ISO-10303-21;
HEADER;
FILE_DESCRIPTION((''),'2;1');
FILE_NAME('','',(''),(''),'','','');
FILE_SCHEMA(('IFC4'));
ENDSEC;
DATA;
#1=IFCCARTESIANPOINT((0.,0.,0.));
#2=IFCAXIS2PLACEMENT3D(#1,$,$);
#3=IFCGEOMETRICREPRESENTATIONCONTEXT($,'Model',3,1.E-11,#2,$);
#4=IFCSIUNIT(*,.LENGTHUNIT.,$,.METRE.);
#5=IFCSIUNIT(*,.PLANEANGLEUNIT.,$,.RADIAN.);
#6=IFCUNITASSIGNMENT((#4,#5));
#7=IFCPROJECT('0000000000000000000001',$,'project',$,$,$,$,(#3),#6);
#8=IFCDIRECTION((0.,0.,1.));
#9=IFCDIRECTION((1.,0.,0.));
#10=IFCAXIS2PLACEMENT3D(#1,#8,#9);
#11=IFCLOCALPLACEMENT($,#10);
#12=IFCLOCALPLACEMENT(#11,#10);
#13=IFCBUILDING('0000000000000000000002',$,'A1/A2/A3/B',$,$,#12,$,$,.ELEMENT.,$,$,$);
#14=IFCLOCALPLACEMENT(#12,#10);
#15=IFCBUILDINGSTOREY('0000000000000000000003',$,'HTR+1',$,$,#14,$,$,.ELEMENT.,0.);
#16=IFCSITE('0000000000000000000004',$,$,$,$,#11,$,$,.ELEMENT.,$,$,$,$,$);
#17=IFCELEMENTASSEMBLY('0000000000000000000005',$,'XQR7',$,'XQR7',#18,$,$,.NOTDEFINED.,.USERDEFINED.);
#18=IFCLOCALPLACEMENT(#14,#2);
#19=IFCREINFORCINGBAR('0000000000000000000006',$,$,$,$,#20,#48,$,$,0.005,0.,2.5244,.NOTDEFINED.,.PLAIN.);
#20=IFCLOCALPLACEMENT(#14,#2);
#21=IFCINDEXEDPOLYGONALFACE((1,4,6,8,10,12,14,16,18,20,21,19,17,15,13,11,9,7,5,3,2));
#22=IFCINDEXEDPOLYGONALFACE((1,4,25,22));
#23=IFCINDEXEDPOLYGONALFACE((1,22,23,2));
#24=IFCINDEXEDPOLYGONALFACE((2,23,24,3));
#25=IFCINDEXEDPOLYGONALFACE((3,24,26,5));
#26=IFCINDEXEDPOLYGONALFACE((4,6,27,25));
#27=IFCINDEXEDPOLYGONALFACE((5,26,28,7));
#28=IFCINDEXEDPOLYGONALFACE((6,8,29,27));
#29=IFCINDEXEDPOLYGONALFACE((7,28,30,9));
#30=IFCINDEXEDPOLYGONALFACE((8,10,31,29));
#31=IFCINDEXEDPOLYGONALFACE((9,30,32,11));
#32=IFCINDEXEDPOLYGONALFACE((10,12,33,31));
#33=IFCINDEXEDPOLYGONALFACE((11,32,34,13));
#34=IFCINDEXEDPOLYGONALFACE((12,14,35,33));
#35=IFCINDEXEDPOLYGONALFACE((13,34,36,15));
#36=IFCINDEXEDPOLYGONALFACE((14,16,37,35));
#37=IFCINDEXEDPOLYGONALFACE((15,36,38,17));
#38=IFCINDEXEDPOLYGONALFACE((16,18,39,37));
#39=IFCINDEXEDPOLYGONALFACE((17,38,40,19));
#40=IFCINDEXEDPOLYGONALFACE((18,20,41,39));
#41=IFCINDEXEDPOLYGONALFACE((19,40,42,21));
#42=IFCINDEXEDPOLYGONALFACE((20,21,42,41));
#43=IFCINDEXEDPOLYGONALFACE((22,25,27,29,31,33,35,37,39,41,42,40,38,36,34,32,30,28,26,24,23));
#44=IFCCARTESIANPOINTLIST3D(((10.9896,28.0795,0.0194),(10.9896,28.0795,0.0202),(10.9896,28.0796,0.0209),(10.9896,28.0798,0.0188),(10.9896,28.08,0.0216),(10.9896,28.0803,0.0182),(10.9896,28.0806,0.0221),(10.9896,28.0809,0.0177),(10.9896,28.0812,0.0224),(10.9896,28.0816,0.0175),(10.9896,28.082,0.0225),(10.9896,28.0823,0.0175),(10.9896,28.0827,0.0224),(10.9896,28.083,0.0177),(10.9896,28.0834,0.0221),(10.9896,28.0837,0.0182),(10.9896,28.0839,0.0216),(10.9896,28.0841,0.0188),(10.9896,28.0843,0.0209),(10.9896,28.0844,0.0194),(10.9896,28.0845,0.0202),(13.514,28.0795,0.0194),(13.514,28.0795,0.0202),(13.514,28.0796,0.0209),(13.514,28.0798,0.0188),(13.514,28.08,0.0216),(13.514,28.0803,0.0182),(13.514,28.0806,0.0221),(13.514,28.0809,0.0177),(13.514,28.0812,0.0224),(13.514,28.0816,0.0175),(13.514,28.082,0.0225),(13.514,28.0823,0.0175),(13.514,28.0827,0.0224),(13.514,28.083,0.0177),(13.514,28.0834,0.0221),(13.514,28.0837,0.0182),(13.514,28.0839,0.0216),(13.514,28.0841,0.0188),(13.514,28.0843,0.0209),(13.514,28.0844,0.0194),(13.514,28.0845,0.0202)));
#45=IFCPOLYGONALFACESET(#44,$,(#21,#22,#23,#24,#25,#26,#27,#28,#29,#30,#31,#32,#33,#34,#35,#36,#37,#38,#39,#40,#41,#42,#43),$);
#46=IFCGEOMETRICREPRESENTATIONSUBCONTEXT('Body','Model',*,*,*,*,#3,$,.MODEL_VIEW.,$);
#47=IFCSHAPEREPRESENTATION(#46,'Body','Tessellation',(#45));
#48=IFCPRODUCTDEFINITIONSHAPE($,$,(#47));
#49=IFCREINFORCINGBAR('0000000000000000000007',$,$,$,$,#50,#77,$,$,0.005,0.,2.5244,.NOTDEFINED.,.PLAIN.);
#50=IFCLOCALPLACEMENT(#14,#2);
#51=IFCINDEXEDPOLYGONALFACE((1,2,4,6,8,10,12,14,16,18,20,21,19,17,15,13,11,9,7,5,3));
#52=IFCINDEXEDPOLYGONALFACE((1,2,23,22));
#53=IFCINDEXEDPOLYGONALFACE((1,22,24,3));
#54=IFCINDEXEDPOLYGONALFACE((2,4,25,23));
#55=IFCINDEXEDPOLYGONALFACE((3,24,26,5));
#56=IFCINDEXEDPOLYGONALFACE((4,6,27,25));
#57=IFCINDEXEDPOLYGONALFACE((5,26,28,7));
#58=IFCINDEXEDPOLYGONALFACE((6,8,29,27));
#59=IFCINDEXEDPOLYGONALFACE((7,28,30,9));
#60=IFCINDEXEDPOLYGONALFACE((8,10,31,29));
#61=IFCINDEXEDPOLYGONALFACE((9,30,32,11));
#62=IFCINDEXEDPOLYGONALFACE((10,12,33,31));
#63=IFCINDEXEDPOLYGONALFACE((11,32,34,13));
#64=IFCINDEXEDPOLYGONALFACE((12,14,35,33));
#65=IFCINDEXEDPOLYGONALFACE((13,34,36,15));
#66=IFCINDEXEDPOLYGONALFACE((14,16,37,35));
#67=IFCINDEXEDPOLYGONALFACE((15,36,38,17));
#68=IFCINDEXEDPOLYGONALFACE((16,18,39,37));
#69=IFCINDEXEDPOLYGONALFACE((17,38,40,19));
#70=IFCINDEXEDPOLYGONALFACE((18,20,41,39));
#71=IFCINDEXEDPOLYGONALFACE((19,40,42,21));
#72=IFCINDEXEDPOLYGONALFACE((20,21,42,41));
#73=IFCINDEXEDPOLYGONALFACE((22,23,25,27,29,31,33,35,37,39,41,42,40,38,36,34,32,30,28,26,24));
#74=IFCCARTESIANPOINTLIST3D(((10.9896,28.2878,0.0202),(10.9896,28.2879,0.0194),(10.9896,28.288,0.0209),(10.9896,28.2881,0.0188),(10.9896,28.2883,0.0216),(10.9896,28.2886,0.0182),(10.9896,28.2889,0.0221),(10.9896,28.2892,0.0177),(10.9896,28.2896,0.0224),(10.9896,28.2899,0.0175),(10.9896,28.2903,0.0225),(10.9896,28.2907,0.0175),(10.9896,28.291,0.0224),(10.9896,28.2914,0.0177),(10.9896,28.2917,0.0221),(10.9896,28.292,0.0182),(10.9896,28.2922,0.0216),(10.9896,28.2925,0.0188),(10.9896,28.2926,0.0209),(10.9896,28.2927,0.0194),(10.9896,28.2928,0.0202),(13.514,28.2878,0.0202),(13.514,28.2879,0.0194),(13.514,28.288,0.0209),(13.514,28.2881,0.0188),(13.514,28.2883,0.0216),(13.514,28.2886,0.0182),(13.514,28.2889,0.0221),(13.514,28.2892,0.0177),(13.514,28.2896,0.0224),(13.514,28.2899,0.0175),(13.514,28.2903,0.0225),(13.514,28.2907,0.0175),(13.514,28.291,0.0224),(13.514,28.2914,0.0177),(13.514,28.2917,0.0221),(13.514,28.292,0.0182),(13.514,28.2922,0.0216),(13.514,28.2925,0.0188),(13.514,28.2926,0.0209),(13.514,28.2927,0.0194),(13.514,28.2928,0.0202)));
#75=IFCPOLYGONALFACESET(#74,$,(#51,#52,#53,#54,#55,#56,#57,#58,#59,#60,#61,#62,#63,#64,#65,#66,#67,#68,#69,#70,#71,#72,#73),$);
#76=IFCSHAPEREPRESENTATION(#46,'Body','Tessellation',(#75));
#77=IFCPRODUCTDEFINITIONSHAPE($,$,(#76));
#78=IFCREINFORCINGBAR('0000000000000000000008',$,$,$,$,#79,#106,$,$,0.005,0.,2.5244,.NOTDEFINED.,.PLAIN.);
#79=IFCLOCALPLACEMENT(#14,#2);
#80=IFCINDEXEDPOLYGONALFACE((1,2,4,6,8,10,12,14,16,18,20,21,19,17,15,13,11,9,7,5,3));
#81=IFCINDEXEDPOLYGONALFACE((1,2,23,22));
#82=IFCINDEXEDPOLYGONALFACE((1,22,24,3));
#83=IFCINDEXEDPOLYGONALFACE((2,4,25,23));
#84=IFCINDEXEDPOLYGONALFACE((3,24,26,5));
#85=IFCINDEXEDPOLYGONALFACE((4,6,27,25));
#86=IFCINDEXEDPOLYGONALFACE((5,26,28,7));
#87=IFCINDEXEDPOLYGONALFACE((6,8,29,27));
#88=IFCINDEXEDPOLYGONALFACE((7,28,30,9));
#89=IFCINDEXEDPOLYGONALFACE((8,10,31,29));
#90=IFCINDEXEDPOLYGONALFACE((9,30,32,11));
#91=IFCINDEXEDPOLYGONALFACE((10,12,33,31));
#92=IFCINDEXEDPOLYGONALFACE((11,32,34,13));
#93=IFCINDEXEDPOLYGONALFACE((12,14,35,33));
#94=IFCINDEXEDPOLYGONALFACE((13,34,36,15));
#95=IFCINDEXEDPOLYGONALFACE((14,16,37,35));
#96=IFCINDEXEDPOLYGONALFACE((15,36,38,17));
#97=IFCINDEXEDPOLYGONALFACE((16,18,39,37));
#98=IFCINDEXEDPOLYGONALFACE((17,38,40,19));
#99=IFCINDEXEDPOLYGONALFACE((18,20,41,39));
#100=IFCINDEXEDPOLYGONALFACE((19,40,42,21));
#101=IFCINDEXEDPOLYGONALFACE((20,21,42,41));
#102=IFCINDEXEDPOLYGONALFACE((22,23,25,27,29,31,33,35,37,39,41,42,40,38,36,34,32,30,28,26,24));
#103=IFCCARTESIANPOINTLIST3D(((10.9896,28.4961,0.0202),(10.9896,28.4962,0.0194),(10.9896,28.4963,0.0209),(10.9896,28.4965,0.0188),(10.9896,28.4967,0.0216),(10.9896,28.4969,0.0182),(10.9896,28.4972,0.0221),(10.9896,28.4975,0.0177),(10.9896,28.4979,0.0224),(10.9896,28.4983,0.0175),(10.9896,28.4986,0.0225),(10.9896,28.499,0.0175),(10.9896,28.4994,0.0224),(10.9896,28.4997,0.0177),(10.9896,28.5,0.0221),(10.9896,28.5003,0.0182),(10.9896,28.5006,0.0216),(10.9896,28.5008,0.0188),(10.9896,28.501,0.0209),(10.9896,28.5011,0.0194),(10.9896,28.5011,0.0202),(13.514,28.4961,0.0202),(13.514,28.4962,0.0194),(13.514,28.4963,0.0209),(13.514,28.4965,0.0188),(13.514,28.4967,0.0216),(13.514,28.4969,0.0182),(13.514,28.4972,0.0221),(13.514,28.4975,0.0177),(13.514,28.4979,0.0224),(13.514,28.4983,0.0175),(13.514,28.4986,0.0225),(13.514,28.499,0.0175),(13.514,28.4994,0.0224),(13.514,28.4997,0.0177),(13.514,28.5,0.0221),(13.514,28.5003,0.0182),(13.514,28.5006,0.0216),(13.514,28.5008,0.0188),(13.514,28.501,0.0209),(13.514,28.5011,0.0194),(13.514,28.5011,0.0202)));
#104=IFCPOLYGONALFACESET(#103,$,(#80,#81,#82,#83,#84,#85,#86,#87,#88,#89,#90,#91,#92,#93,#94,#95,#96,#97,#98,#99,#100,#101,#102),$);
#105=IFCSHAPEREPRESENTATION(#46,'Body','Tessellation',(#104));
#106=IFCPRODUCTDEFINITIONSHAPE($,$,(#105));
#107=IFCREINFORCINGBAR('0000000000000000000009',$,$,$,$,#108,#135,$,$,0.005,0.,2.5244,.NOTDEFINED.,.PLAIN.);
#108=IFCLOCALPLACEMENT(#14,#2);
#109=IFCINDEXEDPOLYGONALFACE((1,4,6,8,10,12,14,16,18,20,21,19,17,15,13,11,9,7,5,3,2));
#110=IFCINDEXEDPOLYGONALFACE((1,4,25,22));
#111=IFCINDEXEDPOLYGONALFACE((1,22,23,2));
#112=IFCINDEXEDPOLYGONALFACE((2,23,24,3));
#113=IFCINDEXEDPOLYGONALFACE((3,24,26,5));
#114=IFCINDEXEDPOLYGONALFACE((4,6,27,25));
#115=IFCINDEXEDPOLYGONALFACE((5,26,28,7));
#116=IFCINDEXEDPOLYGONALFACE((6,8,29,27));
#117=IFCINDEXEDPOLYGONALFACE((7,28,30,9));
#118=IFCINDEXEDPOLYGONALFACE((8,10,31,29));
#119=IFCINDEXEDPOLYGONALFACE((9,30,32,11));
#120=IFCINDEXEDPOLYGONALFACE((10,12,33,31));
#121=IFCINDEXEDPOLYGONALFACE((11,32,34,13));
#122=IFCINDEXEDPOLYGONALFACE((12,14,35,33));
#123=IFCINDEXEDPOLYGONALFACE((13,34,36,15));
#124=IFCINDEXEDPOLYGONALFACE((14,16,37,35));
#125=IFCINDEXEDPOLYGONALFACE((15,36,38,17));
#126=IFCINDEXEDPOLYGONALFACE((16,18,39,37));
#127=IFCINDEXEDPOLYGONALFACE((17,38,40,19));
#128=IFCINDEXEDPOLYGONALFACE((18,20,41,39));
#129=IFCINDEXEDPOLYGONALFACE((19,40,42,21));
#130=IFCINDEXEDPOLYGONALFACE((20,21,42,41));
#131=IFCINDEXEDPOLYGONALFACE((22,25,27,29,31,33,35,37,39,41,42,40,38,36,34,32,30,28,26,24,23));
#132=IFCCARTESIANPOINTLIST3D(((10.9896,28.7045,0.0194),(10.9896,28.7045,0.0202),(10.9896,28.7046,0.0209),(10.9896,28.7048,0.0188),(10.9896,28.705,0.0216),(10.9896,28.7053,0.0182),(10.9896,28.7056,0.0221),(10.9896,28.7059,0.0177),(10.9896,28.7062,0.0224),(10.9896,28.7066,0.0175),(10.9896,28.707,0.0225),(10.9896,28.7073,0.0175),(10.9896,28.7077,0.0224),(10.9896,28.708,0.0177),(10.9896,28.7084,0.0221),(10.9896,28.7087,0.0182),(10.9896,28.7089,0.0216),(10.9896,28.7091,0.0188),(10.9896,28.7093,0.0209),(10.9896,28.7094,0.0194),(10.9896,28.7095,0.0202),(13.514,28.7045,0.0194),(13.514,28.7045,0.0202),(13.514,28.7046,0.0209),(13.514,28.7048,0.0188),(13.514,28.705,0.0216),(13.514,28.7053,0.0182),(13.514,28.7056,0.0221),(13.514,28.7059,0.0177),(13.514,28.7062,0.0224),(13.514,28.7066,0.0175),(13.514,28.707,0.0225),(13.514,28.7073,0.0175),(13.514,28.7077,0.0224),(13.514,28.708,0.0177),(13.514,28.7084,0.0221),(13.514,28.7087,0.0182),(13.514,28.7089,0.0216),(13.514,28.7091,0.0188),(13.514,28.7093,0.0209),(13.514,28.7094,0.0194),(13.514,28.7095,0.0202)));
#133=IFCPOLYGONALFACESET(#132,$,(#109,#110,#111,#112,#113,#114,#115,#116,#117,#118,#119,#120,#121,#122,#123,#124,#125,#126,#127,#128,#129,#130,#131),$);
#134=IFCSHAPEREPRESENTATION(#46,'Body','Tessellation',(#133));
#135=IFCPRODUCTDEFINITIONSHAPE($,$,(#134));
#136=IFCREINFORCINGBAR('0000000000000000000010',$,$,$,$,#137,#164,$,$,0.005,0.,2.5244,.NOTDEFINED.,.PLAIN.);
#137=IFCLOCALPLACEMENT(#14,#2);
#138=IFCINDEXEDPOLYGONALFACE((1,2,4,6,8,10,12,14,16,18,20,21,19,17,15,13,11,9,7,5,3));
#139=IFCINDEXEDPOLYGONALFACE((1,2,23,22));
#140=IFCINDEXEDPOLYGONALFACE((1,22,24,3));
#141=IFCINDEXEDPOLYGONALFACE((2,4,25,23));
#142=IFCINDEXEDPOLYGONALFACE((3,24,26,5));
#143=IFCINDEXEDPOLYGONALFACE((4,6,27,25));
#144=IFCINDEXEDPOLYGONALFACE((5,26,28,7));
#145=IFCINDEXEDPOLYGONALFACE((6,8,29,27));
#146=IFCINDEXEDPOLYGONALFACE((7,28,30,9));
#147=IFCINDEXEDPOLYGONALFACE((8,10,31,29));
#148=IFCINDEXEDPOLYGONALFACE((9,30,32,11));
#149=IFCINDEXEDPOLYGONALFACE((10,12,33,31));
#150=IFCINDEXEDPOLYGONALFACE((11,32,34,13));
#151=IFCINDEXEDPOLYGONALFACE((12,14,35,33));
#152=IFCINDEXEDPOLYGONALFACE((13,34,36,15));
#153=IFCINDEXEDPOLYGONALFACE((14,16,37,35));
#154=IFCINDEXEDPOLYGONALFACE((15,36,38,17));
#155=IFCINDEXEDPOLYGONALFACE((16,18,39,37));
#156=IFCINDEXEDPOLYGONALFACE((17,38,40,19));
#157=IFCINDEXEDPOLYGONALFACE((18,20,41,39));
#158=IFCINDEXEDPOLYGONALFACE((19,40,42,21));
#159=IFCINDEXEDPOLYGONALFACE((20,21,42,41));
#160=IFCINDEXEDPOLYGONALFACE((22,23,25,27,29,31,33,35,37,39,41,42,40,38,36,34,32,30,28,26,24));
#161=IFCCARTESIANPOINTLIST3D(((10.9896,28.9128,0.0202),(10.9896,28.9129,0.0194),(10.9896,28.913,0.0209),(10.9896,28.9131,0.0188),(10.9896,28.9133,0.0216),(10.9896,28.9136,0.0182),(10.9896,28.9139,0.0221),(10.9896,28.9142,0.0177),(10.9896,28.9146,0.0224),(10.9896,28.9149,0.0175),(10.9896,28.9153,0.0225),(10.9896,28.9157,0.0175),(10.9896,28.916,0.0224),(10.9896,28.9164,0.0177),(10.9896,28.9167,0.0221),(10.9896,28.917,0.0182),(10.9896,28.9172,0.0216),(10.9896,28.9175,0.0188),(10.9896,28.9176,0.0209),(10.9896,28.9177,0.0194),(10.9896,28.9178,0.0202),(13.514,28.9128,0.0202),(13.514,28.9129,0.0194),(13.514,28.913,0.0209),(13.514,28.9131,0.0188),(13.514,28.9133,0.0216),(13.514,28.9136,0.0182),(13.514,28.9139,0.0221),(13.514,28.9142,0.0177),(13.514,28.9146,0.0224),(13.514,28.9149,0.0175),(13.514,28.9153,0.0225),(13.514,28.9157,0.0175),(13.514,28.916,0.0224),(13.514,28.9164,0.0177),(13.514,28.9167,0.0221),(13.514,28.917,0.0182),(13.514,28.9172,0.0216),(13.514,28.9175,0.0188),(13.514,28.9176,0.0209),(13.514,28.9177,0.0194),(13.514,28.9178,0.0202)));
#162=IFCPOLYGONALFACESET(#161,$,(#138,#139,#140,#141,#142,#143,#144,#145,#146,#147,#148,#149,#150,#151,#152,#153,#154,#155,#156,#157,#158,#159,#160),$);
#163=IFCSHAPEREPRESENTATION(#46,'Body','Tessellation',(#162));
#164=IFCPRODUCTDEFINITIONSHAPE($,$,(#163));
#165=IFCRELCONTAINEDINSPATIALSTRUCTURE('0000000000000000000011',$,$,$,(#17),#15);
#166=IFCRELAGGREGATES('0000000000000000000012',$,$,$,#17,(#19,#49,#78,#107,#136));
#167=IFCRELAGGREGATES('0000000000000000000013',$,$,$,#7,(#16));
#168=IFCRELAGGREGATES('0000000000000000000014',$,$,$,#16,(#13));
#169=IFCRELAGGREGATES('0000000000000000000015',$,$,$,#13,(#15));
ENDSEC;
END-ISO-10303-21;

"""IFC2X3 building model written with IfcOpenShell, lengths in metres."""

from ifc_helpers import new_model, entity, si_unit, origin, origin_with_axes, place, context, subcontext, project, spatial, shape, element, aggregate, save


model = new_model("IFC2X3")

# Units and contexts
model_context = context("Model", 3, precision=1e-11, world=origin())
body_context = subcontext(model_context, "Body", "Model", "MODEL_VIEW")
ifc_project = project(units=[si_unit("LENGTHUNIT", "METRE"), si_unit("PLANEANGLEUNIT", "RADIAN")], contexts=[model_context])

# Site, building, storey
site_placement = place(None, origin_with_axes())
site = spatial("IfcSite", under=ifc_project, at=site_placement, CompositionType="ELEMENT")
building_placement = place(site_placement, origin_with_axes())
building = spatial("IfcBuilding", under=site, at=building_placement, Name="A1/A2/A3/B", CompositionType="ELEMENT")
storey_placement = place(building_placement, origin_with_axes())
storey = spatial("IfcBuildingStorey", under=building, at=storey_placement, Name="HTR+1", CompositionType="ELEMENT", Elevation=0.0)

# Element assembly, reinforcing bars
assembly_1_placement = place(storey_placement, origin_with_axes())
assembly_1 = element("IfcElementAssembly", 1, at=assembly_1_placement, inside=storey, Name="XQR7", ObjectType="XQR7", AssemblyPlace="NOTDEFINED", PredefinedType="USERDEFINED")
reinforcing_bar_1_placement = place(assembly_1_placement, origin_with_axes())
reinforcing_bar_1 = element("IfcReinforcingBar", 2, at=reinforcing_bar_1_placement, BarLength=2.5244, BarRole="NOTDEFINED", BarSurface="PLAIN", CrossSectionArea=0.0, NominalDiameter=0.005, shapes=[
    shape(body_context, "Body", "AdvancedSweptSolid", [entity("IfcSweptDiskSolid", entity("IfcPolyline", [entity("IfcCartesianPoint", [10.9896, 28.082, 0.02]), entity("IfcCartesianPoint", [13.514, 28.082, 0.02])]), 0.0025, None, 0.0, 2.5244)]),
    shape(body_context, "Body", "AdvancedSweptSolid", [entity("IfcSweptDiskSolid", entity("IfcPolyline", [entity("IfcCartesianPoint", [10.9896, 28.082, 0.02]), entity("IfcCartesianPoint", [13.514, 28.082, 0.02])]), 0.0025, None, 0.0, 2.5244)]),
])
reinforcing_bar_2_placement = place(assembly_1_placement, origin_with_axes())
reinforcing_bar_2 = element("IfcReinforcingBar", 3, at=reinforcing_bar_2_placement, BarLength=2.5244, BarRole="NOTDEFINED", BarSurface="PLAIN", CrossSectionArea=0.0, NominalDiameter=0.005, shapes=[
    shape(body_context, "Body", "AdvancedSweptSolid", [entity("IfcSweptDiskSolid", entity("IfcPolyline", [entity("IfcCartesianPoint", [10.9896, 28.2903, 0.02]), entity("IfcCartesianPoint", [13.514, 28.2903, 0.02])]), 0.0025, None, 0.0, 2.5244)]),
    shape(body_context, "Body", "AdvancedSweptSolid", [entity("IfcSweptDiskSolid", entity("IfcPolyline", [entity("IfcCartesianPoint", [10.9896, 28.2903, 0.02]), entity("IfcCartesianPoint", [13.514, 28.2903, 0.02])]), 0.0025, None, 0.0, 2.5244)]),
])
reinforcing_bar_3_placement = place(assembly_1_placement, origin_with_axes())
reinforcing_bar_3 = element("IfcReinforcingBar", 4, at=reinforcing_bar_3_placement, BarLength=2.5244, BarRole="NOTDEFINED", BarSurface="PLAIN", CrossSectionArea=0.0, NominalDiameter=0.005, shapes=[
    shape(body_context, "Body", "AdvancedSweptSolid", [entity("IfcSweptDiskSolid", entity("IfcPolyline", [entity("IfcCartesianPoint", [10.9896, 28.4986, 0.02]), entity("IfcCartesianPoint", [13.514, 28.4986, 0.02])]), 0.0025, None, 0.0, 2.5244)]),
    shape(body_context, "Body", "AdvancedSweptSolid", [entity("IfcSweptDiskSolid", entity("IfcPolyline", [entity("IfcCartesianPoint", [10.9896, 28.4986, 0.02]), entity("IfcCartesianPoint", [13.514, 28.4986, 0.02])]), 0.0025, None, 0.0, 2.5244)]),
])
reinforcing_bar_4_placement = place(assembly_1_placement, origin_with_axes())
reinforcing_bar_4 = element("IfcReinforcingBar", 5, at=reinforcing_bar_4_placement, BarLength=2.5244, BarRole="NOTDEFINED", BarSurface="PLAIN", CrossSectionArea=0.0, NominalDiameter=0.005, shapes=[
    shape(body_context, "Body", "AdvancedSweptSolid", [entity("IfcSweptDiskSolid", entity("IfcPolyline", [entity("IfcCartesianPoint", [10.9896, 28.707, 0.02]), entity("IfcCartesianPoint", [13.514, 28.707, 0.02])]), 0.0025, None, 0.0, 2.5244)]),
    shape(body_context, "Body", "AdvancedSweptSolid", [entity("IfcSweptDiskSolid", entity("IfcPolyline", [entity("IfcCartesianPoint", [10.9896, 28.707, 0.02]), entity("IfcCartesianPoint", [13.514, 28.707, 0.02])]), 0.0025, None, 0.0, 2.5244)]),
])
reinforcing_bar_5_placement = place(assembly_1_placement, origin_with_axes())
reinforcing_bar_5 = element("IfcReinforcingBar", 6, at=reinforcing_bar_5_placement, BarLength=2.5244, BarRole="NOTDEFINED", BarSurface="PLAIN", CrossSectionArea=0.0, NominalDiameter=0.005, shapes=[
    shape(body_context, "Body", "AdvancedSweptSolid", [entity("IfcSweptDiskSolid", entity("IfcPolyline", [entity("IfcCartesianPoint", [10.9896, 28.9153, 0.02]), entity("IfcCartesianPoint", [13.514, 28.9153, 0.02])]), 0.0025, None, 0.0, 2.5244)]),
    shape(body_context, "Body", "AdvancedSweptSolid", [entity("IfcSweptDiskSolid", entity("IfcPolyline", [entity("IfcCartesianPoint", [10.9896, 28.9153, 0.02]), entity("IfcCartesianPoint", [13.514, 28.9153, 0.02])]), 0.0025, None, 0.0, 2.5244)]),
])
aggregate(assembly_1, [reinforcing_bar_1, reinforcing_bar_2, reinforcing_bar_3, reinforcing_bar_4, reinforcing_bar_5])

save(model, "model.ifc")
